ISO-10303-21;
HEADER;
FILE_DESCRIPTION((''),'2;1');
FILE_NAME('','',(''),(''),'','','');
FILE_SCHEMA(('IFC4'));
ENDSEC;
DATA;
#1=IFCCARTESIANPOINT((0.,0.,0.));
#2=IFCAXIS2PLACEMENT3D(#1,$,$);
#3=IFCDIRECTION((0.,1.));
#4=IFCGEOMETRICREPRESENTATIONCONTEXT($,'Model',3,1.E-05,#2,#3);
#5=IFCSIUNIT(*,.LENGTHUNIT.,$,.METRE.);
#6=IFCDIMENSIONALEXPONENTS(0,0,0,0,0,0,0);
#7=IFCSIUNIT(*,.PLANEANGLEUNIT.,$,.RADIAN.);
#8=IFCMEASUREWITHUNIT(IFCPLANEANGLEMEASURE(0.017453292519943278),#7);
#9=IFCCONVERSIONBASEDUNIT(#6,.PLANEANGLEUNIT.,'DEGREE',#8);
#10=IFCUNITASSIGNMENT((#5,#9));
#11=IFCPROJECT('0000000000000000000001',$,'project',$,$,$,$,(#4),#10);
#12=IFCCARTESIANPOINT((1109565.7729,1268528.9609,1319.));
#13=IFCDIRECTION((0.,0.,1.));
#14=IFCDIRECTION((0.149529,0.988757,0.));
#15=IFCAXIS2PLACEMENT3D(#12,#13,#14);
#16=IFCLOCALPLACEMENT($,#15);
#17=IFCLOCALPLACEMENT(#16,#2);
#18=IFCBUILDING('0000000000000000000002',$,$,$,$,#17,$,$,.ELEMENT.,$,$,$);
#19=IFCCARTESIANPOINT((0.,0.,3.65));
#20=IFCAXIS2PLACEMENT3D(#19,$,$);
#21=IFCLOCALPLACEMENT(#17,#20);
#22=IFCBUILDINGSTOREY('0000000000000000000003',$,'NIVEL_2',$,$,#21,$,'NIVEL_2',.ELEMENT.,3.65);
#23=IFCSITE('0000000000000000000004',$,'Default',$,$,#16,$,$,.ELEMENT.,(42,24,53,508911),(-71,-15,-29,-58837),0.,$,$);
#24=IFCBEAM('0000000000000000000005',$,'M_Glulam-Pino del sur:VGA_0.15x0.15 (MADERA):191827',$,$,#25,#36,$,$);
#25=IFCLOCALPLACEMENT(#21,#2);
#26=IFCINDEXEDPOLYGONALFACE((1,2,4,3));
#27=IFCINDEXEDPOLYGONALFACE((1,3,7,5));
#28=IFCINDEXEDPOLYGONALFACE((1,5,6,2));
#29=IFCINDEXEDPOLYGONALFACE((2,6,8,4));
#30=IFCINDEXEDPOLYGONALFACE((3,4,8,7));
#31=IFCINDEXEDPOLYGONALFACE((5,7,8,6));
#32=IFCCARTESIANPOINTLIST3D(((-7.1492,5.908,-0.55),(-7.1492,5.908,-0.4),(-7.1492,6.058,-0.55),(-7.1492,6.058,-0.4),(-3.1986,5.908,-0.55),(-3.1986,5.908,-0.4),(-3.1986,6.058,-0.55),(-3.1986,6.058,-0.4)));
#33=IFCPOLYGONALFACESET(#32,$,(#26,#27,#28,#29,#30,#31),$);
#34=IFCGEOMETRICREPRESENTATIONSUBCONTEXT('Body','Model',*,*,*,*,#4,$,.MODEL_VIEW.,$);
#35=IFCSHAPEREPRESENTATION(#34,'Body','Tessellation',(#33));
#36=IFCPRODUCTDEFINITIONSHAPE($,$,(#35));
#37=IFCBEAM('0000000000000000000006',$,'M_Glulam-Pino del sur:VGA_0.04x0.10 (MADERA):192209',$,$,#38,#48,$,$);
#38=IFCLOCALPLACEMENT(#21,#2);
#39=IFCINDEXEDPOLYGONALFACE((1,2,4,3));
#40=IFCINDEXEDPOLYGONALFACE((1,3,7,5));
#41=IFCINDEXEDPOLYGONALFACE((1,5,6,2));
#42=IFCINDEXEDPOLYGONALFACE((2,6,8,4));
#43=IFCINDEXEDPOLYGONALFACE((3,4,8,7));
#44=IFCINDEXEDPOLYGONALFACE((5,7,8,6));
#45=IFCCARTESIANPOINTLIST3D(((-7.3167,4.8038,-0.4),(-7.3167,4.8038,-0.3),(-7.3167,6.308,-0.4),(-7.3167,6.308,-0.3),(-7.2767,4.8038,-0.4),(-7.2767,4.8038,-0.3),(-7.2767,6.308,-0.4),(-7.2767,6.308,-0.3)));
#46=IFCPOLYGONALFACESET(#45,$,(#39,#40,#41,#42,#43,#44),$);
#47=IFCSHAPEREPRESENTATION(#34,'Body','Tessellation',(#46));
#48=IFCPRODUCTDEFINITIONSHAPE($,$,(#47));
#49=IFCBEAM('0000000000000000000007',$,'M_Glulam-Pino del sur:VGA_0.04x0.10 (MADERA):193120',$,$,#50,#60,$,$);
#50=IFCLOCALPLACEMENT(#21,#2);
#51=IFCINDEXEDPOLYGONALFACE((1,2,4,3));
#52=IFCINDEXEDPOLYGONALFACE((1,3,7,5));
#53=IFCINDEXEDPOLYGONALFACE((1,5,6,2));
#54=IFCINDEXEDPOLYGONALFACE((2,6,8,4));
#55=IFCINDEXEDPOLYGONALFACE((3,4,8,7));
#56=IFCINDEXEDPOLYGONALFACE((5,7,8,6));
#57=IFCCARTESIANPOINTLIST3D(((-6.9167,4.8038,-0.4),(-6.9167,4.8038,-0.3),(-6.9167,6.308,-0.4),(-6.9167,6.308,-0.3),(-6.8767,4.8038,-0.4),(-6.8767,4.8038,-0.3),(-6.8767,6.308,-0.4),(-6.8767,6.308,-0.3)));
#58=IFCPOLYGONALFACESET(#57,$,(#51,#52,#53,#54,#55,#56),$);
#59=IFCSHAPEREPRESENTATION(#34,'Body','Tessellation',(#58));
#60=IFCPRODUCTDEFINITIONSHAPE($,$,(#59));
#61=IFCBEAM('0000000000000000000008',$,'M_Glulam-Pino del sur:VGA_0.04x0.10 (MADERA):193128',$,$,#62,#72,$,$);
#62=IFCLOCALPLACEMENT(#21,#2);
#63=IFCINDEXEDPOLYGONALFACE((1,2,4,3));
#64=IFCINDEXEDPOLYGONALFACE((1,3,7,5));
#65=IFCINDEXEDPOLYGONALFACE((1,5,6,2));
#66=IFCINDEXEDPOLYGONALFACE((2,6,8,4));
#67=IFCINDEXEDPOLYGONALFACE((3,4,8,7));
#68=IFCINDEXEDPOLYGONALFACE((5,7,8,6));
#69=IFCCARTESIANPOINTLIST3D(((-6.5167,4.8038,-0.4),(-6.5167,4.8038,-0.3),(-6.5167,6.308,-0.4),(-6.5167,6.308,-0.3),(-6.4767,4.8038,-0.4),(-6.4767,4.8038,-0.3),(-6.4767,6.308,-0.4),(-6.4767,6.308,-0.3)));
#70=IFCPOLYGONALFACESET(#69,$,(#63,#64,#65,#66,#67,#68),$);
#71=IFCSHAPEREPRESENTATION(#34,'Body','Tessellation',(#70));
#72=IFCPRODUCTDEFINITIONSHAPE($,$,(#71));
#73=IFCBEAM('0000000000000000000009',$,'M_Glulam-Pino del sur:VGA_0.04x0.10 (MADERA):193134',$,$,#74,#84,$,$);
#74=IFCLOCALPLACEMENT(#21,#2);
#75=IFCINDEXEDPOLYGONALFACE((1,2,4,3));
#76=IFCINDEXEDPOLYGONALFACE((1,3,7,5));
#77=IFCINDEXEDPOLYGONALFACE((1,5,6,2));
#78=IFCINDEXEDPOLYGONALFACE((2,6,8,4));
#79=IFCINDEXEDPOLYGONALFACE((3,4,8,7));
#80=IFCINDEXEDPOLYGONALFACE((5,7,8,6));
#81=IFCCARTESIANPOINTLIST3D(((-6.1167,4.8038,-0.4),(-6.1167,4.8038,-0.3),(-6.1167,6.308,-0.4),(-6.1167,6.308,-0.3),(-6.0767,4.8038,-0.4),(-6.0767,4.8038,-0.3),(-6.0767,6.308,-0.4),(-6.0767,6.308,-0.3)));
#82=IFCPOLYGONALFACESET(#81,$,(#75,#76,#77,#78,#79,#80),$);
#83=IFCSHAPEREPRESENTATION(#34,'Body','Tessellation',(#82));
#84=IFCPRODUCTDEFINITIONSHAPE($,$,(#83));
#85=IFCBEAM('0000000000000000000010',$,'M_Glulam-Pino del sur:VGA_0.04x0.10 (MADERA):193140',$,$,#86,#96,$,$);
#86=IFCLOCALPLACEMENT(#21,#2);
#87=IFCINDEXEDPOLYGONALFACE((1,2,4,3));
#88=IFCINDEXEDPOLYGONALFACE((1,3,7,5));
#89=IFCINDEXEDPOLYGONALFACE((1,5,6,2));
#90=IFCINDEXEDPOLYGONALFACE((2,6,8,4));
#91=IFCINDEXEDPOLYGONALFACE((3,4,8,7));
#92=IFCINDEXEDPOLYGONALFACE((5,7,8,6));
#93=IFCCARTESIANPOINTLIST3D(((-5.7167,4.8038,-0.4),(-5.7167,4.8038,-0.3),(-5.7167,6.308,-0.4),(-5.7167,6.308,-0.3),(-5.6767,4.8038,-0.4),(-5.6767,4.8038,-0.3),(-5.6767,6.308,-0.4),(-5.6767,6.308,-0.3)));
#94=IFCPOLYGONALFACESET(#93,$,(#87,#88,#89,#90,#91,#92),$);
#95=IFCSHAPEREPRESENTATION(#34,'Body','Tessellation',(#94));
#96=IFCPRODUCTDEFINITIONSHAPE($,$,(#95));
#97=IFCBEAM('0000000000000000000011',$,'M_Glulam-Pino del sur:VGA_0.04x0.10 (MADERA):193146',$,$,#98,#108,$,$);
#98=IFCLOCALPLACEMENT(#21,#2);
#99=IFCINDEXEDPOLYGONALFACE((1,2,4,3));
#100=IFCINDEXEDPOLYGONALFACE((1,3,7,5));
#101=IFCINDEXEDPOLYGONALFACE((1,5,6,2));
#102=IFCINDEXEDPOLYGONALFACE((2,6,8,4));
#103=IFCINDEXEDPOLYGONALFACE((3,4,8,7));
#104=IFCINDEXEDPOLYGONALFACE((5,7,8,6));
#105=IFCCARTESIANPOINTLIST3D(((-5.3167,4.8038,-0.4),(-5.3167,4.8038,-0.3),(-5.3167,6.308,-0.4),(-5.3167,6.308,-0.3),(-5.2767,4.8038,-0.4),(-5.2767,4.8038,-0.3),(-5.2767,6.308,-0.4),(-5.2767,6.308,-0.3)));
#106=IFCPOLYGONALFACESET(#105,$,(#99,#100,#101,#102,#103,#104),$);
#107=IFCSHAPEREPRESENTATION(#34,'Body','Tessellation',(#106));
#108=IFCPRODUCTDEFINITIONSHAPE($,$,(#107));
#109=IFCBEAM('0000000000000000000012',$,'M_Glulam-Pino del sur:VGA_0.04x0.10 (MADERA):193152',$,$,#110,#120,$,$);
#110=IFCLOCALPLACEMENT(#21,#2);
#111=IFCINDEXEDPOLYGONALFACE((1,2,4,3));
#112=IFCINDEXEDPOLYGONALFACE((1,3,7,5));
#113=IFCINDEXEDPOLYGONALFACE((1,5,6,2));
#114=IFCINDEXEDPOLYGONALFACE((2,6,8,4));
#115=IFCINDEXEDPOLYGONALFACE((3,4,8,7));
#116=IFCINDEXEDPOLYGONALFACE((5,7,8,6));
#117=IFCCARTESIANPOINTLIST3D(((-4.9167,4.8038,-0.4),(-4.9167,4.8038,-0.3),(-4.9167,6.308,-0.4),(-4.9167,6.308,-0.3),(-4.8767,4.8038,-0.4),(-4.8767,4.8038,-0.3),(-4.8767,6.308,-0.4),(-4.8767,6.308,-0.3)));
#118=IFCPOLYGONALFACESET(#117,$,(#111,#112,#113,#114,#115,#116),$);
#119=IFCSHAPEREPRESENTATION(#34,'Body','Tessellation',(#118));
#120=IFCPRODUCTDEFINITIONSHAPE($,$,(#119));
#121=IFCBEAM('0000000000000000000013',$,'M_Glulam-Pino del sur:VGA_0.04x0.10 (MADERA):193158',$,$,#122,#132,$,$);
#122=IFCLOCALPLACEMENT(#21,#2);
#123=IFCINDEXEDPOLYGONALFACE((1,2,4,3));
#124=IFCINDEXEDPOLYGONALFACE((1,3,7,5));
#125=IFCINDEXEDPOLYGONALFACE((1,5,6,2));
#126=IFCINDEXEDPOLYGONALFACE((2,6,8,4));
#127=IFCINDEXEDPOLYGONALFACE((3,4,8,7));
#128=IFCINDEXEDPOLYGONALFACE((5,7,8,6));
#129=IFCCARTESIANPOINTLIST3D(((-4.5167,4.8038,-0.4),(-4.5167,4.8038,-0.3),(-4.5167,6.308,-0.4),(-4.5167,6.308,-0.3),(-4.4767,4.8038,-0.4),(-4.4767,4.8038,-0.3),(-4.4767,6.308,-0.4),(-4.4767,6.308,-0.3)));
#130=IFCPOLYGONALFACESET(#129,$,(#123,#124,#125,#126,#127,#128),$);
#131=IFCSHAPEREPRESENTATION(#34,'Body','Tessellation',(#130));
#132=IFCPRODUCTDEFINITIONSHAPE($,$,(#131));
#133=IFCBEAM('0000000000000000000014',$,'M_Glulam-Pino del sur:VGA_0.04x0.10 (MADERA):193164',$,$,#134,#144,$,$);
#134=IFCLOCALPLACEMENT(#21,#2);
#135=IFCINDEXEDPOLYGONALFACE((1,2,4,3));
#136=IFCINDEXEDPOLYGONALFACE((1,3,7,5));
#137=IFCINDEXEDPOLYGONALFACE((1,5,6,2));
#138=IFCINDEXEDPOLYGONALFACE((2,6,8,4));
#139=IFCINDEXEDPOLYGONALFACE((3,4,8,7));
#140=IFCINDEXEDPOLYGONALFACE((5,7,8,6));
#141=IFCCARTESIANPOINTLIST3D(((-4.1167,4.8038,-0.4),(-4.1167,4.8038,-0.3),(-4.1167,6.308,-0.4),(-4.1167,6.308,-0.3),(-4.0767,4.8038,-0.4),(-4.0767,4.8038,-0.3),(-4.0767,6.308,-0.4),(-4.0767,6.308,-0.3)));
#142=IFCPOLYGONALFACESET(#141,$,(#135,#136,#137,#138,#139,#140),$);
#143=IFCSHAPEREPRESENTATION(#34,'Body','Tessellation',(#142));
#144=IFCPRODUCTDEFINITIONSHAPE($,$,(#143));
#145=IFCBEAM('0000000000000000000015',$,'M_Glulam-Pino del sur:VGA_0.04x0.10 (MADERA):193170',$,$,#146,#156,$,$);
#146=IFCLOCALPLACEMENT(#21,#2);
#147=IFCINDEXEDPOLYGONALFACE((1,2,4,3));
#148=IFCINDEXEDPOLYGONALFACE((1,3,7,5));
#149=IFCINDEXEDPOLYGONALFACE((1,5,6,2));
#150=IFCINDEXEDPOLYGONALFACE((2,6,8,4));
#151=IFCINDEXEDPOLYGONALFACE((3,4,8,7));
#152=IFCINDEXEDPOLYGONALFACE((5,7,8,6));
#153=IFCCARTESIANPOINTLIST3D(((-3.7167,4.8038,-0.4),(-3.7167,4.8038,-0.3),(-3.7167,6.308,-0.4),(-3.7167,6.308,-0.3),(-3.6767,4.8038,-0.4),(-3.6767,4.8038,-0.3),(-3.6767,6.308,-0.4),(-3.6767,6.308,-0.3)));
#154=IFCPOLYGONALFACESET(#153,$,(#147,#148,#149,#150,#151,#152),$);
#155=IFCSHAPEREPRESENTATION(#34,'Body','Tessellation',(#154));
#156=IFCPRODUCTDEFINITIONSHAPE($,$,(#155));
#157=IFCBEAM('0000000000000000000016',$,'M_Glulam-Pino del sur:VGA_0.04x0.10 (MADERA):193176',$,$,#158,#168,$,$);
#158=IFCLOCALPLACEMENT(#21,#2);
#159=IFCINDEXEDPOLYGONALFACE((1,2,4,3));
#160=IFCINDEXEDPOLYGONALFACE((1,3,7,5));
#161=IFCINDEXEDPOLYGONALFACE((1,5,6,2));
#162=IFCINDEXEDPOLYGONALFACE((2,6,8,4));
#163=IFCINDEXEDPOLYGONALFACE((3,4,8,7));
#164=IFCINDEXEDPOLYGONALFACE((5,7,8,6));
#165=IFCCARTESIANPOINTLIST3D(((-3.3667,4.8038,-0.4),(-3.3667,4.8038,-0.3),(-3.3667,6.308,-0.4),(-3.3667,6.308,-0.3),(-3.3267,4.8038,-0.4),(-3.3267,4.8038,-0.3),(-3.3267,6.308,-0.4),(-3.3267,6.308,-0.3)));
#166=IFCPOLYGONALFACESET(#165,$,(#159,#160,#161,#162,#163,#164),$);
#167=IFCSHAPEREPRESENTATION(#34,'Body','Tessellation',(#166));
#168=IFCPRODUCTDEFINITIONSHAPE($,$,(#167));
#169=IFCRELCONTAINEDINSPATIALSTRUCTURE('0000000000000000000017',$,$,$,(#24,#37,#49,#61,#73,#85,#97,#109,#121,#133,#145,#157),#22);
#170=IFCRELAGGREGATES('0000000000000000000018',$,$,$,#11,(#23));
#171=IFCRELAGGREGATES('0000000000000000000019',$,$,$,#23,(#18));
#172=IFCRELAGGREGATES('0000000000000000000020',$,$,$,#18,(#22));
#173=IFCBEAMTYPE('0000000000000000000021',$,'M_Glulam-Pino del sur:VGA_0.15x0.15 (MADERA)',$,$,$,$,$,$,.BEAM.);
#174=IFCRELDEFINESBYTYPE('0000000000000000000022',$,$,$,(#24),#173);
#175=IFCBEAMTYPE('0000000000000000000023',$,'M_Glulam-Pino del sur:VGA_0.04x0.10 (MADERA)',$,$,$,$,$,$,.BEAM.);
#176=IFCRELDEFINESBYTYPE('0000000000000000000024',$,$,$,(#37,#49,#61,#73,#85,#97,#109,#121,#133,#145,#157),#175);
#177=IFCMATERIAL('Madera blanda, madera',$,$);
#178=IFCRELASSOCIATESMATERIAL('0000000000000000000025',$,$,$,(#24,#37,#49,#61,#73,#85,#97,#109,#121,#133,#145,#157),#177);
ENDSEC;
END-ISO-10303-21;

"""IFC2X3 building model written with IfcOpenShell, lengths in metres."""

from ifc_helpers import new_model, entity, si_unit, converted_unit, direction, frame, frame_2d, origin, origin_2d_with_axis, place, context, subcontext, project, spatial, rectangle, extrude, material, type_object, element, save


model = new_model("IFC2X3")

# Units and contexts
model_context = context("Model", 3, precision=1e-05, world=origin(), true_north=direction((0.0, 1.0)))
body_context = subcontext(model_context, "Body", "Model", "MODEL_VIEW")
ifc_project = project(units=[si_unit("LENGTHUNIT", "METRE"), converted_unit("PLANEANGLEUNIT", "DEGREE", entity("IfcPlaneAngleMeasure", 0.017453292519943278), si_unit("PLANEANGLEUNIT", "RADIAN"), dimensions=[0, 0, 0, 0, 0, 0, 0])], contexts=[model_context])

# Site, building, storey
site_placement = place(None, frame((1109565.7729, 1268528.9609, 1319.0), z_axis=(0.0, 0.0, 1.0), x_axis=(0.149529, 0.988757, 0.0)))
site = spatial("IfcSite", under=ifc_project, at=site_placement, Name="Default", CompositionType="ELEMENT", RefLatitude=(42, 24, 53, 508911), RefLongitude=(-71, -15, -29, -58837), RefElevation=0.0)
building_placement = place(site_placement, origin())
building = spatial("IfcBuilding", under=site, at=building_placement, CompositionType="ELEMENT")
storey_placement = place(building_placement, frame((0.0, 0.0, 3.65)))
storey = spatial("IfcBuildingStorey", under=building, at=storey_placement, Name="NIVEL_2", LongName="NIVEL_2", CompositionType="ELEMENT", Elevation=3.65)

# Beams
ifc_material_1 = material(Name="Madera blanda, madera")
beam_type_1 = type_object("IfcBeamType", Name="M_Glulam-Pino del sur:VGA_0.15x0.15 (MADERA)", PredefinedType="BEAM")
beam_placement = place(storey_placement, frame((-7.1492, 5.983, -0.4)))
element("IfcBeam", 1, at=beam_placement, inside=storey, type_object=beam_type_1, material=ifc_material_1, Name="M_Glulam-Pino del sur:VGA_0.15x0.15 (MADERA):191827", context=body_context, shape_type="SweptSolid", body=[
    extrude(rectangle(XDim=0.15, YDim=0.15, at=frame_2d((0.0, 0.0), x_axis=(1.0, 0.0))), frame((0.0001, 0.0, -0.075), z_axis=(1.0, 0.0, 0.0), x_axis=(0.0, 0.0, -1.0)), (0.0, 0.0, 1.0), 3.9505),
])
beam_type_2 = type_object("IfcBeamType", Name="M_Glulam-Pino del sur:VGA_0.04x0.10 (MADERA)", PredefinedType="BEAM")
for number, where, z_axis, x_axis, name in (
    (2, (-7.2967, 4.8038, 0.0), (0.0, 0.0, 1.0), (0.0, 1.0, 0.0), "M_Glulam-Pino del sur:VGA_0.04x0.10 (MADERA):192209"),
    (3, (-6.8967, 4.8038, 0.0), (0.0, 0.0, 1.0), (0.0, 1.0, 0.0), "M_Glulam-Pino del sur:VGA_0.04x0.10 (MADERA):193120"),
    (4, (-6.4967, 4.8038, 0.0), (0.0, 0.0, 1.0), (0.0, 1.0, 0.0), "M_Glulam-Pino del sur:VGA_0.04x0.10 (MADERA):193128"),
    (5, (-6.0967, 4.8038, 0.0), (0.0, 0.0, 1.0), (0.0, 1.0, 0.0), "M_Glulam-Pino del sur:VGA_0.04x0.10 (MADERA):193134"),
    (6, (-5.6967, 4.8038, 0.0), (0.0, 0.0, 1.0), (0.0, 1.0, 0.0), "M_Glulam-Pino del sur:VGA_0.04x0.10 (MADERA):193140"),
    (7, (-5.2967, 4.8038, 0.0), (0.0, 0.0, 1.0), (0.0, 1.0, 0.0), "M_Glulam-Pino del sur:VGA_0.04x0.10 (MADERA):193146"),
):
    element("IfcBeam", number, at=place(storey_placement, frame(where, z_axis=z_axis, x_axis=x_axis)), inside=storey, type_object=beam_type_2, material=ifc_material_1, Name=name, context=body_context, shape_type="SweptSolid", body=[
        extrude(rectangle(XDim=0.1, YDim=0.04, at=origin_2d_with_axis()), frame((0.0, 0.0, -0.35), z_axis=(1.0, 0.0, 0.0), x_axis=(0.0, 0.0, -1.0)), (0.0, 0.0, 1.0), 1.5042),
    ])
for number, where, z_axis, x_axis, name in (
    (8, (-4.8967, 4.8038, 0.0), (0.0, 0.0, 1.0), (0.0, 1.0, 0.0), "M_Glulam-Pino del sur:VGA_0.04x0.10 (MADERA):193152"),
    (9, (-4.4967, 4.8038, 0.0), (0.0, 0.0, 1.0), (0.0, 1.0, 0.0), "M_Glulam-Pino del sur:VGA_0.04x0.10 (MADERA):193158"),
    (10, (-4.0967, 4.8038, 0.0), (0.0, 0.0, 1.0), (0.0, 1.0, 0.0), "M_Glulam-Pino del sur:VGA_0.04x0.10 (MADERA):193164"),
    (11, (-3.6967, 4.8038, 0.0), (0.0, 0.0, 1.0), (0.0, 1.0, 0.0), "M_Glulam-Pino del sur:VGA_0.04x0.10 (MADERA):193170"),
    (12, (-3.3467, 4.8038, 0.0), (0.0, 0.0, 1.0), (0.0, 1.0, 0.0), "M_Glulam-Pino del sur:VGA_0.04x0.10 (MADERA):193176"),
):
    element("IfcBeam", number, at=place(storey_placement, frame(where, z_axis=z_axis, x_axis=x_axis)), inside=storey, type_object=beam_type_2, material=ifc_material_1, Name=name, context=body_context, shape_type="SweptSolid", body=[
        extrude(rectangle(XDim=0.1, YDim=0.04, at=frame_2d((0.0, 0.0), x_axis=(1.0, 0.0))), frame((0.0, 0.0, -0.35), z_axis=(1.0, 0.0, 0.0), x_axis=(0.0, 0.0, -1.0)), (0.0, 0.0, 1.0), 1.5042),
    ])

save(model, "model.ifc")
